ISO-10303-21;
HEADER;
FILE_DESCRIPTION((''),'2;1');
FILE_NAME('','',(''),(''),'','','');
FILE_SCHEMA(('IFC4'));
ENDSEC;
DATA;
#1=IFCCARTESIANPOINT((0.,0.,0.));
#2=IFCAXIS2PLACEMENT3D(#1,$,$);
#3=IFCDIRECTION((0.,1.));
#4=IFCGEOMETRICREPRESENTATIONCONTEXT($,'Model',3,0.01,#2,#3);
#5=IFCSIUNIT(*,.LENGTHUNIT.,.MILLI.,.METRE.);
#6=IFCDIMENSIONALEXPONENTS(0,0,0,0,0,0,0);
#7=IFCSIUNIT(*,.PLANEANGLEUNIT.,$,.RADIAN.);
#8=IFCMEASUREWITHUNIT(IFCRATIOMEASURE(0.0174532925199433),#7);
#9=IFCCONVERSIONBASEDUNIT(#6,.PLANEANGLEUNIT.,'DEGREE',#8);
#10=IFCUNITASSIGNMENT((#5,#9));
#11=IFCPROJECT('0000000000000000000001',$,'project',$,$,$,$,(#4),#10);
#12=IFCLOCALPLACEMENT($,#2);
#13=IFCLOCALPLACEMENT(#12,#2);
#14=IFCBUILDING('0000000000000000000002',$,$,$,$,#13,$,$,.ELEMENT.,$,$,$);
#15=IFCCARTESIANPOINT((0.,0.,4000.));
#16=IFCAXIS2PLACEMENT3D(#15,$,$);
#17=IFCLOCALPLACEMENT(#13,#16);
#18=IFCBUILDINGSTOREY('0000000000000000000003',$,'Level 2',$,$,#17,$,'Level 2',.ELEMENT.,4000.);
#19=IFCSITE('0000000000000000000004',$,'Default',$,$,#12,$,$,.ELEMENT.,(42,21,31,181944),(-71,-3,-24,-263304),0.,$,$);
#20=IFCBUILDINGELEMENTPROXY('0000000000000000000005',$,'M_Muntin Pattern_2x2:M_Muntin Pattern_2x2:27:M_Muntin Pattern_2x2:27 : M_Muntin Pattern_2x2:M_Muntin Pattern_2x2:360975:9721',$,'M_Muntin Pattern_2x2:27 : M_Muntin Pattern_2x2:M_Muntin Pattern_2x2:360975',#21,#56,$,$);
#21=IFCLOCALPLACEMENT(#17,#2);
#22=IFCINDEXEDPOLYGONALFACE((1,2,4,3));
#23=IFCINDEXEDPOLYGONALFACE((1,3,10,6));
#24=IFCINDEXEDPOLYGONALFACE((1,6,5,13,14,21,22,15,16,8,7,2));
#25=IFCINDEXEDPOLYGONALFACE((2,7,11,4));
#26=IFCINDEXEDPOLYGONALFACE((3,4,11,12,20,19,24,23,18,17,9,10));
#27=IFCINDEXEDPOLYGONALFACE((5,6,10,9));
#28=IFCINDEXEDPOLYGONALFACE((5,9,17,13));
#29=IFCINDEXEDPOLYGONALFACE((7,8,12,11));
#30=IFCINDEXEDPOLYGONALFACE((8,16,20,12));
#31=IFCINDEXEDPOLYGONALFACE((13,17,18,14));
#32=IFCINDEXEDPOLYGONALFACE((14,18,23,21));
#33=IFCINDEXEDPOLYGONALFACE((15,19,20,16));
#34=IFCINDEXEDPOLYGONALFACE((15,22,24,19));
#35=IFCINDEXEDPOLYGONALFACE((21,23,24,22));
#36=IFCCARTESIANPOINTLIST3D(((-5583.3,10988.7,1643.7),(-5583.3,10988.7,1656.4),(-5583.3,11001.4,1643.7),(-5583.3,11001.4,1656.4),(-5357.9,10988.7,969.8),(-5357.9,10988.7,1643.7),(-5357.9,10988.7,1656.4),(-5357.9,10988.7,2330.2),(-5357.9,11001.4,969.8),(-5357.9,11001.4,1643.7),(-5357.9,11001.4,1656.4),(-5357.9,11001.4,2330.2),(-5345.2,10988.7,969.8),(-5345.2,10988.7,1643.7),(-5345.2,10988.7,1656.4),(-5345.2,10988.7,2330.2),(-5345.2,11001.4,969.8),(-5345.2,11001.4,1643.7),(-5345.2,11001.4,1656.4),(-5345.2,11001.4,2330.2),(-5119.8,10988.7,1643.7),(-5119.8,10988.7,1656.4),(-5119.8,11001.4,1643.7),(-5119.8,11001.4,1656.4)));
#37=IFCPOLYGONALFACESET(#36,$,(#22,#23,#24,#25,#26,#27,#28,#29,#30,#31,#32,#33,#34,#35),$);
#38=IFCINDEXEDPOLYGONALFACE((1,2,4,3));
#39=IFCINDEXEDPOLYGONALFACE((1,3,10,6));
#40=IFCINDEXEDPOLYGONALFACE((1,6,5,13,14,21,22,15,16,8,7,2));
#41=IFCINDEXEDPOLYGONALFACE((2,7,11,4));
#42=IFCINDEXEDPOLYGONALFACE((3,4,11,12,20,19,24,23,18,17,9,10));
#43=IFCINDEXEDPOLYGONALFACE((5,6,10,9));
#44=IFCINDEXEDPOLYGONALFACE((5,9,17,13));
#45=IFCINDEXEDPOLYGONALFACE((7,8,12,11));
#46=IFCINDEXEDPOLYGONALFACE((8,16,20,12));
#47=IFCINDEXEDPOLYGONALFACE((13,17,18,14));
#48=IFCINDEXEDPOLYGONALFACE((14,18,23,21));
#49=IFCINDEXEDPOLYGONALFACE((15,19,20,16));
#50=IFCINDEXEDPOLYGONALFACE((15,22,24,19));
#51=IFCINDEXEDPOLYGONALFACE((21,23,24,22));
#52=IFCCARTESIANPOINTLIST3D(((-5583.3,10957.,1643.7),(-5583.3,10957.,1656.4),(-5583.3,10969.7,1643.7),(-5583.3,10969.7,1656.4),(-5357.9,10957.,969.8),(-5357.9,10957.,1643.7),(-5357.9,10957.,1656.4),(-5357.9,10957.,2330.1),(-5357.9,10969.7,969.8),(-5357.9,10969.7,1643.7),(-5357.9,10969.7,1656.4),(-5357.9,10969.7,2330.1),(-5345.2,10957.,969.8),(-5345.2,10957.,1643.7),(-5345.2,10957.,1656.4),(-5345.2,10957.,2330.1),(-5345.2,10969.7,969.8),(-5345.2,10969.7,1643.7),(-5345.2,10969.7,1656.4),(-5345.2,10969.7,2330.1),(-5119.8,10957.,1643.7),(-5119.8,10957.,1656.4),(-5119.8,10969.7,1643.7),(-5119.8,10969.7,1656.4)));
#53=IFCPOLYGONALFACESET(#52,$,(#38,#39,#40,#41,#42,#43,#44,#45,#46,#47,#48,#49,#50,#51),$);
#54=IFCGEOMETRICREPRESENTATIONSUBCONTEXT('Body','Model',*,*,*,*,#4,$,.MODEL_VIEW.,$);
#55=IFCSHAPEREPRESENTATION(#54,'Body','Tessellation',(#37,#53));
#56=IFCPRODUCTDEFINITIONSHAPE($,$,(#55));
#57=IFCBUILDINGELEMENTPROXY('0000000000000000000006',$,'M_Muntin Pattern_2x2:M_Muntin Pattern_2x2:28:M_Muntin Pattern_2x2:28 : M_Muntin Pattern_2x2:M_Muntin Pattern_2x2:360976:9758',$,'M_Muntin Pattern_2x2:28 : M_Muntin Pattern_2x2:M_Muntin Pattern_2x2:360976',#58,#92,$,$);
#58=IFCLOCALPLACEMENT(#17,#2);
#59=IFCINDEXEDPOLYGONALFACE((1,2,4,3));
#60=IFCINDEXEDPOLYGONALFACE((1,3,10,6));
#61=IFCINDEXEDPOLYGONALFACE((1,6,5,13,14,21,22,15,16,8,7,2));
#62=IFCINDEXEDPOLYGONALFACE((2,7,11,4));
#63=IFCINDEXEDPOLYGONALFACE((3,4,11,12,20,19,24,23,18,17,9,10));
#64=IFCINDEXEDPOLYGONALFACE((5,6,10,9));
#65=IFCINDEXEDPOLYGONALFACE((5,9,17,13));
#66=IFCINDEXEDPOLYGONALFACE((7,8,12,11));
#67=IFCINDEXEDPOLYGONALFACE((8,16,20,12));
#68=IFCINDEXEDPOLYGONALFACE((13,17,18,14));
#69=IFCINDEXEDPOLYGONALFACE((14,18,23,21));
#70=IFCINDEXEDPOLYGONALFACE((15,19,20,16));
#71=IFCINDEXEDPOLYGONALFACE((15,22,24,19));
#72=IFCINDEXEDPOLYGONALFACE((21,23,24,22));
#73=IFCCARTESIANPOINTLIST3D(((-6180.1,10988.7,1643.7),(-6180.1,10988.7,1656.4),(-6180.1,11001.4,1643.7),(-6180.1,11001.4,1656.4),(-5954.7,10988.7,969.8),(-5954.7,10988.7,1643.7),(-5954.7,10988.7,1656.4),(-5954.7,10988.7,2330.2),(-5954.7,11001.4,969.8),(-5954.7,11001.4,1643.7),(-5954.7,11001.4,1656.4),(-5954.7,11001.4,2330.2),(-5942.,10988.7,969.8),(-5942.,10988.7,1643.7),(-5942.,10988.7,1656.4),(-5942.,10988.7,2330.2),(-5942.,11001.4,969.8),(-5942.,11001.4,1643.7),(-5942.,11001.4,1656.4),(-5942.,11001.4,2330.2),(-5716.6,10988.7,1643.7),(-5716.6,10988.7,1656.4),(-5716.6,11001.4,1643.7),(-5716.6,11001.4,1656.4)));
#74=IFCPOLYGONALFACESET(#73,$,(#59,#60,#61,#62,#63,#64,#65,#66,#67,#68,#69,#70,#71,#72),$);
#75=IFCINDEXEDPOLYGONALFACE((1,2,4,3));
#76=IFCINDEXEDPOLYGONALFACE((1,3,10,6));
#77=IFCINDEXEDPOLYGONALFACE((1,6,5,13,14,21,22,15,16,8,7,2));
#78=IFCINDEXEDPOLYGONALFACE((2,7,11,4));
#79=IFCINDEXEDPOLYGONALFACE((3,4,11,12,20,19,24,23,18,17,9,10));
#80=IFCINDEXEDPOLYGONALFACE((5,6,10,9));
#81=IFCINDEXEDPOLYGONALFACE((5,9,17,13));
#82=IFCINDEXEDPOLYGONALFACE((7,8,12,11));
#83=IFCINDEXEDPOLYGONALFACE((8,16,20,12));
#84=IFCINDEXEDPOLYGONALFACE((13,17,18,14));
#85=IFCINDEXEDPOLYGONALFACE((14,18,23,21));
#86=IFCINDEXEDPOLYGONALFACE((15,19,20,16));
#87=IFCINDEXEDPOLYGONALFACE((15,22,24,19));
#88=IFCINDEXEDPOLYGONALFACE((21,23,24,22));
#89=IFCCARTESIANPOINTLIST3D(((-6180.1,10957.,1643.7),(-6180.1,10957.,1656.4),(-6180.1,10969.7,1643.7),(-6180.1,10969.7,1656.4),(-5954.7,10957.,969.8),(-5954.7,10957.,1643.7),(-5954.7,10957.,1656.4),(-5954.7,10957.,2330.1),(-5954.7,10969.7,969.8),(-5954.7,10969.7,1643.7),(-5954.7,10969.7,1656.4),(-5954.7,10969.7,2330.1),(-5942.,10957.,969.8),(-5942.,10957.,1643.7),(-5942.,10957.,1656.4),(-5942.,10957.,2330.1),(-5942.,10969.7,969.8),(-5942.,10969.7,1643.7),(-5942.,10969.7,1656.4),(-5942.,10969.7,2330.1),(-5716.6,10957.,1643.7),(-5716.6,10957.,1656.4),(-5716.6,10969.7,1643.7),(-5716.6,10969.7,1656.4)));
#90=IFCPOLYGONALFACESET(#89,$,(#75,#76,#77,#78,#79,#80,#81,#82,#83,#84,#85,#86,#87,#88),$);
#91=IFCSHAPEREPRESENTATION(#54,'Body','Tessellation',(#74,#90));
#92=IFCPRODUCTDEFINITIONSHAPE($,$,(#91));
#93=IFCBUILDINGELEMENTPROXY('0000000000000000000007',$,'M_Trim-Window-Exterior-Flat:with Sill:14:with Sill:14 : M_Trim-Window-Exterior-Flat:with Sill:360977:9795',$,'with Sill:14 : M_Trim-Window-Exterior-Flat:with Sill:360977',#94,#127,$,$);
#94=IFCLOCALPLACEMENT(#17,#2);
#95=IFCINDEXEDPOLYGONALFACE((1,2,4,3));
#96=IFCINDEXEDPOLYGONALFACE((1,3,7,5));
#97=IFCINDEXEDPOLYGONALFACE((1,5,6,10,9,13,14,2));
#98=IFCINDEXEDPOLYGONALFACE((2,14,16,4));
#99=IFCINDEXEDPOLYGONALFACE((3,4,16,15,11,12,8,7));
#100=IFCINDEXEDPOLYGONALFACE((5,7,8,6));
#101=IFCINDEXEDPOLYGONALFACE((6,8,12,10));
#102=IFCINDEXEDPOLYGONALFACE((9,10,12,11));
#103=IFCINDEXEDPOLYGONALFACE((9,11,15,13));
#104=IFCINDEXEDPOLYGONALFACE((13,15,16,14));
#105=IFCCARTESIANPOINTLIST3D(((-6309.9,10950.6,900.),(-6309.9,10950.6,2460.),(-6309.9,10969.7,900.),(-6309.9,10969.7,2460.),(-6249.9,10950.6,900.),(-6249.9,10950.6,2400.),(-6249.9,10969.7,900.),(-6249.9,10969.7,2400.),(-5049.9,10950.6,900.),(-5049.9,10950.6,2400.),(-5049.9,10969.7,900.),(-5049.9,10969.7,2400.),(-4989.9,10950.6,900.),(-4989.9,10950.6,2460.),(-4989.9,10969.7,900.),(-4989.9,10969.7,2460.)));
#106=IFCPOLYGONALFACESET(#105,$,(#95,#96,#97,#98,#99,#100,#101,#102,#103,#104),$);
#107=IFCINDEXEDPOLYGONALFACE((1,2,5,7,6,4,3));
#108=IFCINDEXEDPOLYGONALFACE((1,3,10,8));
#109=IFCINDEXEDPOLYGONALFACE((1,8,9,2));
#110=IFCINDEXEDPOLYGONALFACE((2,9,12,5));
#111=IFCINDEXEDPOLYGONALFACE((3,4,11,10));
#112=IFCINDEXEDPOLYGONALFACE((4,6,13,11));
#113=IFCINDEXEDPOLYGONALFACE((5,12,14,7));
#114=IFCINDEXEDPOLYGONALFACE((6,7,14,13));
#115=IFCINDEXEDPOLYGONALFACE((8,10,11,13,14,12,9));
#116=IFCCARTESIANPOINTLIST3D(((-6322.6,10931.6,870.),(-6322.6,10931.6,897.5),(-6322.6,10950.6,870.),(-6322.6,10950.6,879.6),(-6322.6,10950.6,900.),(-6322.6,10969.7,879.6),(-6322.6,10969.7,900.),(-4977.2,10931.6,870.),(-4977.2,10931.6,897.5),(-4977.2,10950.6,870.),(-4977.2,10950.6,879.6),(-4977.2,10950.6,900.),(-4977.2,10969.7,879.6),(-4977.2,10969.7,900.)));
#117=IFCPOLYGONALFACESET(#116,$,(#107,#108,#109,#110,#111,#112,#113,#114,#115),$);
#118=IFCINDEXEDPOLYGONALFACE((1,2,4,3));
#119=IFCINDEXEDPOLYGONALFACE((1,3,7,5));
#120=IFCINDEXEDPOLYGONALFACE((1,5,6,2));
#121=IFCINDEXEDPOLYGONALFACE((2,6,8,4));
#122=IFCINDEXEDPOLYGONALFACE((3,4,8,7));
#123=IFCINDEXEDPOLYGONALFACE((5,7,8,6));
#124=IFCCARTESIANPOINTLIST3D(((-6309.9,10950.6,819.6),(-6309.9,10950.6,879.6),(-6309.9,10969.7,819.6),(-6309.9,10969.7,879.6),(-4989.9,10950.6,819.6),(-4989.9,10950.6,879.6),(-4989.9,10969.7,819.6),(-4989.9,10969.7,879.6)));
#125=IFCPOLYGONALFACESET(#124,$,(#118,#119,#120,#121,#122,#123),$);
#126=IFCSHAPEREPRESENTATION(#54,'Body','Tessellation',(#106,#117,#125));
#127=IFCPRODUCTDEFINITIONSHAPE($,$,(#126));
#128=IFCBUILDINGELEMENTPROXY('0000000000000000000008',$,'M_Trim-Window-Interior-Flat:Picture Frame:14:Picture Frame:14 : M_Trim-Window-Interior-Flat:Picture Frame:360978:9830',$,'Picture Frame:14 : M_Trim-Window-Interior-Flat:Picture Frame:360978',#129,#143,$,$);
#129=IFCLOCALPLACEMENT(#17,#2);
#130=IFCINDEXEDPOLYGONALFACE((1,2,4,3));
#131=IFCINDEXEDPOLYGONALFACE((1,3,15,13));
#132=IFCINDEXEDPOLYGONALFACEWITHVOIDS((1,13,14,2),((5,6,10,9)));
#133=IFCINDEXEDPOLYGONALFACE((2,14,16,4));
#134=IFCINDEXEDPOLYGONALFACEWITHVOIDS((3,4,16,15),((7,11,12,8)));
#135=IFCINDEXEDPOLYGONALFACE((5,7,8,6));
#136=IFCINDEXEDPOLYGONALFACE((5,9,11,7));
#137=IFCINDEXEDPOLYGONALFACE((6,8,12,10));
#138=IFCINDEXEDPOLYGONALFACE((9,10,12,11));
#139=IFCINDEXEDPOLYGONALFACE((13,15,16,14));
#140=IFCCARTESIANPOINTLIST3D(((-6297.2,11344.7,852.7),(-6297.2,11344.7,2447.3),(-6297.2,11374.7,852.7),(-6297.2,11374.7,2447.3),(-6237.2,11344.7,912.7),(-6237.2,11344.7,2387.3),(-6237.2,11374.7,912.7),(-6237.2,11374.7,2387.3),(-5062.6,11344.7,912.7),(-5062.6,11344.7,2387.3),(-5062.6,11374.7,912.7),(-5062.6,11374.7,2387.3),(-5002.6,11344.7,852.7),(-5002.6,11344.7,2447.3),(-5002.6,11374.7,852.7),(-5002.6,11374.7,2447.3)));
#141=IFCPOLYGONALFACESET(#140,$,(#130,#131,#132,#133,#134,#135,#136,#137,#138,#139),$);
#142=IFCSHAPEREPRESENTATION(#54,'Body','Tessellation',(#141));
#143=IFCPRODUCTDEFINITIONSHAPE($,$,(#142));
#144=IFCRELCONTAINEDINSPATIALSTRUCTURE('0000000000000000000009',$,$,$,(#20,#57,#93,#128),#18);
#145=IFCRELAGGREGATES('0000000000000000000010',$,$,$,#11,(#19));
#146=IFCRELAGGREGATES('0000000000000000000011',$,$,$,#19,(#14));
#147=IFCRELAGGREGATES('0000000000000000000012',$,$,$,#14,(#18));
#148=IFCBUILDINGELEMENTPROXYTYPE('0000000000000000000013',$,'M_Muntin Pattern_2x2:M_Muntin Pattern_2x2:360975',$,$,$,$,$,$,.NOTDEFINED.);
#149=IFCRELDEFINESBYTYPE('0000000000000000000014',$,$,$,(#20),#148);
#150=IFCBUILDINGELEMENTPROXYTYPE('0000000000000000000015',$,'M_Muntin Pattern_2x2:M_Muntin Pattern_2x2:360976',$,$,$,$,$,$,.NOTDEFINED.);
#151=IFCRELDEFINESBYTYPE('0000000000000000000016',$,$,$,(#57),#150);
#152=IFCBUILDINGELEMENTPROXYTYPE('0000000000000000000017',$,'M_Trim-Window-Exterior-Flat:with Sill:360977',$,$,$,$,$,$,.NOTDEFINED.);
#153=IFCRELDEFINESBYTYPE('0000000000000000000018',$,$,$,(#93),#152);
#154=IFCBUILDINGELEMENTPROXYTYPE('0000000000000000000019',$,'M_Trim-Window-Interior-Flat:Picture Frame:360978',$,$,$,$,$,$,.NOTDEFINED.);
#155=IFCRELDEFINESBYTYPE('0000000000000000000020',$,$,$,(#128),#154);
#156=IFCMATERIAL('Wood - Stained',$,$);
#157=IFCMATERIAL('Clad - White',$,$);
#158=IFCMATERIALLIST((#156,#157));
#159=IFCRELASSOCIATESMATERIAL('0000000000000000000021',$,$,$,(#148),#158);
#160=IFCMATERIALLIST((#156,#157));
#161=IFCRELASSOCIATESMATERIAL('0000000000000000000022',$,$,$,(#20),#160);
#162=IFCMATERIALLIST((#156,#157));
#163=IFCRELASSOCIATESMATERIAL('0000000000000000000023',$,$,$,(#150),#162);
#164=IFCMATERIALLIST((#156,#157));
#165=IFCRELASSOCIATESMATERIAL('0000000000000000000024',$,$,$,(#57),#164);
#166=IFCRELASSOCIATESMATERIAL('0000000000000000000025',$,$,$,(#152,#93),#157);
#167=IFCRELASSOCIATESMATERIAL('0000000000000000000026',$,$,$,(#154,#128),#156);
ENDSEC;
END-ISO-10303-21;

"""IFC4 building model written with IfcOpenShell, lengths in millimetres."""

from ifc_helpers import new_model, entity, si_unit, converted_unit, direction, frame, frame_2d, origin, place, context, subcontext, project, spatial, polyline, rectangle, outline, extrude, source, transform, mapped, material, material_list, type_object, type_shapes, element, save


model = new_model("IFC4")

# Units and contexts
model_context = context("Model", 3, precision=0.01, world=origin(), true_north=direction((0.0, 1.0)))
body_context = subcontext(model_context, "Body", "Model", "MODEL_VIEW")
ifc_project = project(units=[si_unit("LENGTHUNIT", "METRE", prefix="MILLI"), converted_unit("PLANEANGLEUNIT", "DEGREE", entity("IfcRatioMeasure", 0.0174532925199433), si_unit("PLANEANGLEUNIT", "RADIAN"), dimensions=[0, 0, 0, 0, 0, 0, 0])], contexts=[model_context])

# Site, building, storey
site_placement = place(None, origin())
site = spatial("IfcSite", under=ifc_project, at=site_placement, Name="Default", CompositionType="ELEMENT", RefLatitude=(42, 21, 31, 181944), RefLongitude=(-71, -3, -24, -263304), RefElevation=0.0)
building_placement = place(site_placement, origin())
building = spatial("IfcBuilding", under=site, at=building_placement, CompositionType="ELEMENT")
storey_placement = place(building_placement, frame((0.0, 0.0, 4000.0)))
storey = spatial("IfcBuildingStorey", under=building, at=storey_placement, Name="Level 2", LongName="Level 2", CompositionType="ELEMENT", Elevation=4000.0)

# Building element proxies
ifc_material_1 = material(Name="Wood - Stained")
ifc_material_2 = material(Name="Clad - White")
ifc_material_list_1 = material_list([ifc_material_1, ifc_material_2])
ifc_material_list_2 = material_list([ifc_material_1, ifc_material_2])
building_element_proxy_type_1 = type_object("IfcBuildingElementProxyType", Name="M_Muntin Pattern_2x2:M_Muntin Pattern_2x2:360975", PredefinedType="NOTDEFINED", material=ifc_material_list_2)
shared_shape_1 = source(origin(), body_context, "Body", "SweptSolid", [
    extrude(outline(polyline([(-680.2, 6.4), (-680.2, -6.3), (-6.4, -6.3), (-6.4, -231.7), (6.3, -231.7), (6.3, -6.3), (680.2, -6.3), (680.2, 6.4), (6.3, 6.4), (6.3, 231.7), (-6.4, 231.7), (-6.4, 6.4), (-680.2, 6.4)])), frame((-5351.5, 10988.7, 5650.0), z_axis=(0.0, -1.0, 0.0), x_axis=(0.0, 0.0, -1.0)), (0.0, 0.0, -1.0), 12.7),
    extrude(outline(polyline([(-680.1, 6.4), (-680.1, -6.3), (-6.4, -6.3), (-6.4, -231.7), (6.3, -231.7), (6.3, -6.3), (680.2, -6.3), (680.2, 6.4), (6.3, 6.4), (6.3, 231.7), (-6.4, 231.7), (-6.4, 6.4), (-680.1, 6.4)])), frame((-5351.5, 10957.0, 5650.0), z_axis=(0.0, -1.0, 0.0), x_axis=(0.0, 0.0, -1.0)), (0.0, 0.0, -1.0), 12.7),
])
type_shapes(building_element_proxy_type_1, [shared_shape_1])
proxy_1_placement = place(storey_placement, frame((0.0, 0.0, -4000.0)))
element("IfcBuildingElementProxy", 1, at=proxy_1_placement, inside=storey, type_object=building_element_proxy_type_1, material=ifc_material_list_1, Name="M_Muntin Pattern_2x2:M_Muntin Pattern_2x2:27:M_Muntin Pattern_2x2:27 : M_Muntin Pattern_2x2:M_Muntin Pattern_2x2:360975:9721", ObjectType="M_Muntin Pattern_2x2:27 : M_Muntin Pattern_2x2:M_Muntin Pattern_2x2:360975", context=body_context, shape_type="MappedRepresentation", body=[
    mapped(shared_shape_1, transform((0.0, 0.0, 0.0), scale=1.0)),
])
ifc_material_list_3 = material_list([ifc_material_1, ifc_material_2])
ifc_material_list_4 = material_list([ifc_material_1, ifc_material_2])
building_element_proxy_type_2 = type_object("IfcBuildingElementProxyType", Name="M_Muntin Pattern_2x2:M_Muntin Pattern_2x2:360976", PredefinedType="NOTDEFINED", material=ifc_material_list_4)
shared_shape_2 = source(origin(), body_context, "Body", "SweptSolid", [
    extrude(outline(polyline([(-6.4, -680.1), (6.3, -680.1), (6.3, -6.4), (231.7, -6.4), (231.7, 6.3), (6.3, 6.3), (6.3, 680.2), (-6.4, 680.2), (-6.4, 6.3), (-231.7, 6.3), (-231.7, -6.4), (-6.4, -6.4), (-6.4, -680.1)])), frame((-5948.4, 10988.7, 5650.0), z_axis=(0.0, 1.0, 0.0), x_axis=(1.0, 0.0, 0.0)), (0.0, 0.0, 1.0), 12.7),
    extrude(outline(polyline([(-6.4, -680.1), (6.3, -680.1), (6.3, -6.4), (231.7, -6.4), (231.7, 6.3), (6.3, 6.3), (6.3, 680.2), (-6.4, 680.2), (-6.4, 6.3), (-231.7, 6.3), (-231.7, -6.4), (-6.4, -6.4), (-6.4, -680.1)])), frame((-5948.4, 10957.0, 5650.0), z_axis=(0.0, 1.0, 0.0), x_axis=(1.0, 0.0, 0.0)), (0.0, 0.0, 1.0), 12.7),
])
type_shapes(building_element_proxy_type_2, [shared_shape_2])
proxy_2_placement = place(storey_placement, frame((0.0, 0.0, -4000.0)))
element("IfcBuildingElementProxy", 2, at=proxy_2_placement, inside=storey, type_object=building_element_proxy_type_2, material=ifc_material_list_3, Name="M_Muntin Pattern_2x2:M_Muntin Pattern_2x2:28:M_Muntin Pattern_2x2:28 : M_Muntin Pattern_2x2:M_Muntin Pattern_2x2:360976:9758", ObjectType="M_Muntin Pattern_2x2:28 : M_Muntin Pattern_2x2:M_Muntin Pattern_2x2:360976", context=body_context, shape_type="MappedRepresentation", body=[
    mapped(shared_shape_2, transform((0.0, 0.0, 0.0), scale=1.0)),
])
building_element_proxy_type_3 = type_object("IfcBuildingElementProxyType", Name="M_Trim-Window-Exterior-Flat:with Sill:360977", PredefinedType="NOTDEFINED", material=ifc_material_2)
shared_shape_3 = source(origin(), body_context, "Body", "SweptSolid", [
    extrude(outline(polyline([(-765.0, -660.0), (795.0, -660.0), (795.0, 660.0), (-765.0, 660.0), (-765.0, 600.0), (735.0, 600.0), (735.0, -600.0), (-765.0, -600.0), (-765.0, -660.0)])), frame((-5649.9, 10950.6, 5665.0), z_axis=(0.0, 1.0, 0.0), x_axis=(0.0, 0.0, 1.0)), (0.0, 0.0, 1.0), 19.1),
    extrude(outline(polyline([(-15.2, 0.0), (-15.2, -19.0), (12.3, -19.0), (14.8, 0.0), (14.8, 19.0), (-5.7, 19.0), (-5.7, 0.0), (-15.2, 0.0)])), frame((-6322.6, 10950.6, 4885.2), z_axis=(-1.0, 0.0, 0.0), x_axis=(0.0, 0.0, 1.0)), (0.0, 0.0, -1.0), 1345.4),
    extrude(rectangle(XDim=19.1, YDim=1320.0, at=frame_2d((0.0, 0.0), x_axis=(1.0, 0.0))), frame((-5649.9, 10960.1, 4819.6), z_axis=(0.0, 0.0, 1.0), x_axis=(0.0, 1.0, 0.0)), (0.0, 0.0, 1.0), 60.0),
])
type_shapes(building_element_proxy_type_3, [shared_shape_3])
proxy_3_placement = place(storey_placement, frame((0.0, 0.0, -4000.0)))
element("IfcBuildingElementProxy", 3, at=proxy_3_placement, inside=storey, type_object=building_element_proxy_type_3, material=ifc_material_2, Name="M_Trim-Window-Exterior-Flat:with Sill:14:with Sill:14 : M_Trim-Window-Exterior-Flat:with Sill:360977:9795", ObjectType="with Sill:14 : M_Trim-Window-Exterior-Flat:with Sill:360977", context=body_context, shape_type="MappedRepresentation", body=[
    mapped(shared_shape_3, transform((0.0, 0.0, 0.0), scale=1.0)),
])
building_element_proxy_type_4 = type_object("IfcBuildingElementProxyType", Name="M_Trim-Window-Interior-Flat:Picture Frame:360978", PredefinedType="NOTDEFINED", material=ifc_material_1)
shared_shape_4 = source(origin(), body_context, "Body", "SweptSolid", [
    extrude(outline(polyline([(-797.3, -647.3), (797.3, -647.3), (797.3, 647.3), (-797.3, 647.3), (-797.3, -647.3)]), holes=[polyline([(737.3, 587.3), (737.3, -587.3), (-737.3, -587.3), (-737.3, 587.3), (737.3, 587.3)])]), frame((-5649.9, 11344.7, 5650.0), z_axis=(0.0, 1.0, 0.0), x_axis=(0.0, 0.0, -1.0)), (0.0, 0.0, 1.0), 30.0),
])
type_shapes(building_element_proxy_type_4, [shared_shape_4])
proxy_4_placement = place(storey_placement, frame((0.0, 0.0, -4000.0)))
element("IfcBuildingElementProxy", 4, at=proxy_4_placement, inside=storey, type_object=building_element_proxy_type_4, material=ifc_material_1, Name="M_Trim-Window-Interior-Flat:Picture Frame:14:Picture Frame:14 : M_Trim-Window-Interior-Flat:Picture Frame:360978:9830", ObjectType="Picture Frame:14 : M_Trim-Window-Interior-Flat:Picture Frame:360978", context=body_context, shape_type="MappedRepresentation", body=[
    mapped(shared_shape_4, transform((0.0, 0.0, 0.0), scale=1.0)),
])

save(model, "model.ifc")
